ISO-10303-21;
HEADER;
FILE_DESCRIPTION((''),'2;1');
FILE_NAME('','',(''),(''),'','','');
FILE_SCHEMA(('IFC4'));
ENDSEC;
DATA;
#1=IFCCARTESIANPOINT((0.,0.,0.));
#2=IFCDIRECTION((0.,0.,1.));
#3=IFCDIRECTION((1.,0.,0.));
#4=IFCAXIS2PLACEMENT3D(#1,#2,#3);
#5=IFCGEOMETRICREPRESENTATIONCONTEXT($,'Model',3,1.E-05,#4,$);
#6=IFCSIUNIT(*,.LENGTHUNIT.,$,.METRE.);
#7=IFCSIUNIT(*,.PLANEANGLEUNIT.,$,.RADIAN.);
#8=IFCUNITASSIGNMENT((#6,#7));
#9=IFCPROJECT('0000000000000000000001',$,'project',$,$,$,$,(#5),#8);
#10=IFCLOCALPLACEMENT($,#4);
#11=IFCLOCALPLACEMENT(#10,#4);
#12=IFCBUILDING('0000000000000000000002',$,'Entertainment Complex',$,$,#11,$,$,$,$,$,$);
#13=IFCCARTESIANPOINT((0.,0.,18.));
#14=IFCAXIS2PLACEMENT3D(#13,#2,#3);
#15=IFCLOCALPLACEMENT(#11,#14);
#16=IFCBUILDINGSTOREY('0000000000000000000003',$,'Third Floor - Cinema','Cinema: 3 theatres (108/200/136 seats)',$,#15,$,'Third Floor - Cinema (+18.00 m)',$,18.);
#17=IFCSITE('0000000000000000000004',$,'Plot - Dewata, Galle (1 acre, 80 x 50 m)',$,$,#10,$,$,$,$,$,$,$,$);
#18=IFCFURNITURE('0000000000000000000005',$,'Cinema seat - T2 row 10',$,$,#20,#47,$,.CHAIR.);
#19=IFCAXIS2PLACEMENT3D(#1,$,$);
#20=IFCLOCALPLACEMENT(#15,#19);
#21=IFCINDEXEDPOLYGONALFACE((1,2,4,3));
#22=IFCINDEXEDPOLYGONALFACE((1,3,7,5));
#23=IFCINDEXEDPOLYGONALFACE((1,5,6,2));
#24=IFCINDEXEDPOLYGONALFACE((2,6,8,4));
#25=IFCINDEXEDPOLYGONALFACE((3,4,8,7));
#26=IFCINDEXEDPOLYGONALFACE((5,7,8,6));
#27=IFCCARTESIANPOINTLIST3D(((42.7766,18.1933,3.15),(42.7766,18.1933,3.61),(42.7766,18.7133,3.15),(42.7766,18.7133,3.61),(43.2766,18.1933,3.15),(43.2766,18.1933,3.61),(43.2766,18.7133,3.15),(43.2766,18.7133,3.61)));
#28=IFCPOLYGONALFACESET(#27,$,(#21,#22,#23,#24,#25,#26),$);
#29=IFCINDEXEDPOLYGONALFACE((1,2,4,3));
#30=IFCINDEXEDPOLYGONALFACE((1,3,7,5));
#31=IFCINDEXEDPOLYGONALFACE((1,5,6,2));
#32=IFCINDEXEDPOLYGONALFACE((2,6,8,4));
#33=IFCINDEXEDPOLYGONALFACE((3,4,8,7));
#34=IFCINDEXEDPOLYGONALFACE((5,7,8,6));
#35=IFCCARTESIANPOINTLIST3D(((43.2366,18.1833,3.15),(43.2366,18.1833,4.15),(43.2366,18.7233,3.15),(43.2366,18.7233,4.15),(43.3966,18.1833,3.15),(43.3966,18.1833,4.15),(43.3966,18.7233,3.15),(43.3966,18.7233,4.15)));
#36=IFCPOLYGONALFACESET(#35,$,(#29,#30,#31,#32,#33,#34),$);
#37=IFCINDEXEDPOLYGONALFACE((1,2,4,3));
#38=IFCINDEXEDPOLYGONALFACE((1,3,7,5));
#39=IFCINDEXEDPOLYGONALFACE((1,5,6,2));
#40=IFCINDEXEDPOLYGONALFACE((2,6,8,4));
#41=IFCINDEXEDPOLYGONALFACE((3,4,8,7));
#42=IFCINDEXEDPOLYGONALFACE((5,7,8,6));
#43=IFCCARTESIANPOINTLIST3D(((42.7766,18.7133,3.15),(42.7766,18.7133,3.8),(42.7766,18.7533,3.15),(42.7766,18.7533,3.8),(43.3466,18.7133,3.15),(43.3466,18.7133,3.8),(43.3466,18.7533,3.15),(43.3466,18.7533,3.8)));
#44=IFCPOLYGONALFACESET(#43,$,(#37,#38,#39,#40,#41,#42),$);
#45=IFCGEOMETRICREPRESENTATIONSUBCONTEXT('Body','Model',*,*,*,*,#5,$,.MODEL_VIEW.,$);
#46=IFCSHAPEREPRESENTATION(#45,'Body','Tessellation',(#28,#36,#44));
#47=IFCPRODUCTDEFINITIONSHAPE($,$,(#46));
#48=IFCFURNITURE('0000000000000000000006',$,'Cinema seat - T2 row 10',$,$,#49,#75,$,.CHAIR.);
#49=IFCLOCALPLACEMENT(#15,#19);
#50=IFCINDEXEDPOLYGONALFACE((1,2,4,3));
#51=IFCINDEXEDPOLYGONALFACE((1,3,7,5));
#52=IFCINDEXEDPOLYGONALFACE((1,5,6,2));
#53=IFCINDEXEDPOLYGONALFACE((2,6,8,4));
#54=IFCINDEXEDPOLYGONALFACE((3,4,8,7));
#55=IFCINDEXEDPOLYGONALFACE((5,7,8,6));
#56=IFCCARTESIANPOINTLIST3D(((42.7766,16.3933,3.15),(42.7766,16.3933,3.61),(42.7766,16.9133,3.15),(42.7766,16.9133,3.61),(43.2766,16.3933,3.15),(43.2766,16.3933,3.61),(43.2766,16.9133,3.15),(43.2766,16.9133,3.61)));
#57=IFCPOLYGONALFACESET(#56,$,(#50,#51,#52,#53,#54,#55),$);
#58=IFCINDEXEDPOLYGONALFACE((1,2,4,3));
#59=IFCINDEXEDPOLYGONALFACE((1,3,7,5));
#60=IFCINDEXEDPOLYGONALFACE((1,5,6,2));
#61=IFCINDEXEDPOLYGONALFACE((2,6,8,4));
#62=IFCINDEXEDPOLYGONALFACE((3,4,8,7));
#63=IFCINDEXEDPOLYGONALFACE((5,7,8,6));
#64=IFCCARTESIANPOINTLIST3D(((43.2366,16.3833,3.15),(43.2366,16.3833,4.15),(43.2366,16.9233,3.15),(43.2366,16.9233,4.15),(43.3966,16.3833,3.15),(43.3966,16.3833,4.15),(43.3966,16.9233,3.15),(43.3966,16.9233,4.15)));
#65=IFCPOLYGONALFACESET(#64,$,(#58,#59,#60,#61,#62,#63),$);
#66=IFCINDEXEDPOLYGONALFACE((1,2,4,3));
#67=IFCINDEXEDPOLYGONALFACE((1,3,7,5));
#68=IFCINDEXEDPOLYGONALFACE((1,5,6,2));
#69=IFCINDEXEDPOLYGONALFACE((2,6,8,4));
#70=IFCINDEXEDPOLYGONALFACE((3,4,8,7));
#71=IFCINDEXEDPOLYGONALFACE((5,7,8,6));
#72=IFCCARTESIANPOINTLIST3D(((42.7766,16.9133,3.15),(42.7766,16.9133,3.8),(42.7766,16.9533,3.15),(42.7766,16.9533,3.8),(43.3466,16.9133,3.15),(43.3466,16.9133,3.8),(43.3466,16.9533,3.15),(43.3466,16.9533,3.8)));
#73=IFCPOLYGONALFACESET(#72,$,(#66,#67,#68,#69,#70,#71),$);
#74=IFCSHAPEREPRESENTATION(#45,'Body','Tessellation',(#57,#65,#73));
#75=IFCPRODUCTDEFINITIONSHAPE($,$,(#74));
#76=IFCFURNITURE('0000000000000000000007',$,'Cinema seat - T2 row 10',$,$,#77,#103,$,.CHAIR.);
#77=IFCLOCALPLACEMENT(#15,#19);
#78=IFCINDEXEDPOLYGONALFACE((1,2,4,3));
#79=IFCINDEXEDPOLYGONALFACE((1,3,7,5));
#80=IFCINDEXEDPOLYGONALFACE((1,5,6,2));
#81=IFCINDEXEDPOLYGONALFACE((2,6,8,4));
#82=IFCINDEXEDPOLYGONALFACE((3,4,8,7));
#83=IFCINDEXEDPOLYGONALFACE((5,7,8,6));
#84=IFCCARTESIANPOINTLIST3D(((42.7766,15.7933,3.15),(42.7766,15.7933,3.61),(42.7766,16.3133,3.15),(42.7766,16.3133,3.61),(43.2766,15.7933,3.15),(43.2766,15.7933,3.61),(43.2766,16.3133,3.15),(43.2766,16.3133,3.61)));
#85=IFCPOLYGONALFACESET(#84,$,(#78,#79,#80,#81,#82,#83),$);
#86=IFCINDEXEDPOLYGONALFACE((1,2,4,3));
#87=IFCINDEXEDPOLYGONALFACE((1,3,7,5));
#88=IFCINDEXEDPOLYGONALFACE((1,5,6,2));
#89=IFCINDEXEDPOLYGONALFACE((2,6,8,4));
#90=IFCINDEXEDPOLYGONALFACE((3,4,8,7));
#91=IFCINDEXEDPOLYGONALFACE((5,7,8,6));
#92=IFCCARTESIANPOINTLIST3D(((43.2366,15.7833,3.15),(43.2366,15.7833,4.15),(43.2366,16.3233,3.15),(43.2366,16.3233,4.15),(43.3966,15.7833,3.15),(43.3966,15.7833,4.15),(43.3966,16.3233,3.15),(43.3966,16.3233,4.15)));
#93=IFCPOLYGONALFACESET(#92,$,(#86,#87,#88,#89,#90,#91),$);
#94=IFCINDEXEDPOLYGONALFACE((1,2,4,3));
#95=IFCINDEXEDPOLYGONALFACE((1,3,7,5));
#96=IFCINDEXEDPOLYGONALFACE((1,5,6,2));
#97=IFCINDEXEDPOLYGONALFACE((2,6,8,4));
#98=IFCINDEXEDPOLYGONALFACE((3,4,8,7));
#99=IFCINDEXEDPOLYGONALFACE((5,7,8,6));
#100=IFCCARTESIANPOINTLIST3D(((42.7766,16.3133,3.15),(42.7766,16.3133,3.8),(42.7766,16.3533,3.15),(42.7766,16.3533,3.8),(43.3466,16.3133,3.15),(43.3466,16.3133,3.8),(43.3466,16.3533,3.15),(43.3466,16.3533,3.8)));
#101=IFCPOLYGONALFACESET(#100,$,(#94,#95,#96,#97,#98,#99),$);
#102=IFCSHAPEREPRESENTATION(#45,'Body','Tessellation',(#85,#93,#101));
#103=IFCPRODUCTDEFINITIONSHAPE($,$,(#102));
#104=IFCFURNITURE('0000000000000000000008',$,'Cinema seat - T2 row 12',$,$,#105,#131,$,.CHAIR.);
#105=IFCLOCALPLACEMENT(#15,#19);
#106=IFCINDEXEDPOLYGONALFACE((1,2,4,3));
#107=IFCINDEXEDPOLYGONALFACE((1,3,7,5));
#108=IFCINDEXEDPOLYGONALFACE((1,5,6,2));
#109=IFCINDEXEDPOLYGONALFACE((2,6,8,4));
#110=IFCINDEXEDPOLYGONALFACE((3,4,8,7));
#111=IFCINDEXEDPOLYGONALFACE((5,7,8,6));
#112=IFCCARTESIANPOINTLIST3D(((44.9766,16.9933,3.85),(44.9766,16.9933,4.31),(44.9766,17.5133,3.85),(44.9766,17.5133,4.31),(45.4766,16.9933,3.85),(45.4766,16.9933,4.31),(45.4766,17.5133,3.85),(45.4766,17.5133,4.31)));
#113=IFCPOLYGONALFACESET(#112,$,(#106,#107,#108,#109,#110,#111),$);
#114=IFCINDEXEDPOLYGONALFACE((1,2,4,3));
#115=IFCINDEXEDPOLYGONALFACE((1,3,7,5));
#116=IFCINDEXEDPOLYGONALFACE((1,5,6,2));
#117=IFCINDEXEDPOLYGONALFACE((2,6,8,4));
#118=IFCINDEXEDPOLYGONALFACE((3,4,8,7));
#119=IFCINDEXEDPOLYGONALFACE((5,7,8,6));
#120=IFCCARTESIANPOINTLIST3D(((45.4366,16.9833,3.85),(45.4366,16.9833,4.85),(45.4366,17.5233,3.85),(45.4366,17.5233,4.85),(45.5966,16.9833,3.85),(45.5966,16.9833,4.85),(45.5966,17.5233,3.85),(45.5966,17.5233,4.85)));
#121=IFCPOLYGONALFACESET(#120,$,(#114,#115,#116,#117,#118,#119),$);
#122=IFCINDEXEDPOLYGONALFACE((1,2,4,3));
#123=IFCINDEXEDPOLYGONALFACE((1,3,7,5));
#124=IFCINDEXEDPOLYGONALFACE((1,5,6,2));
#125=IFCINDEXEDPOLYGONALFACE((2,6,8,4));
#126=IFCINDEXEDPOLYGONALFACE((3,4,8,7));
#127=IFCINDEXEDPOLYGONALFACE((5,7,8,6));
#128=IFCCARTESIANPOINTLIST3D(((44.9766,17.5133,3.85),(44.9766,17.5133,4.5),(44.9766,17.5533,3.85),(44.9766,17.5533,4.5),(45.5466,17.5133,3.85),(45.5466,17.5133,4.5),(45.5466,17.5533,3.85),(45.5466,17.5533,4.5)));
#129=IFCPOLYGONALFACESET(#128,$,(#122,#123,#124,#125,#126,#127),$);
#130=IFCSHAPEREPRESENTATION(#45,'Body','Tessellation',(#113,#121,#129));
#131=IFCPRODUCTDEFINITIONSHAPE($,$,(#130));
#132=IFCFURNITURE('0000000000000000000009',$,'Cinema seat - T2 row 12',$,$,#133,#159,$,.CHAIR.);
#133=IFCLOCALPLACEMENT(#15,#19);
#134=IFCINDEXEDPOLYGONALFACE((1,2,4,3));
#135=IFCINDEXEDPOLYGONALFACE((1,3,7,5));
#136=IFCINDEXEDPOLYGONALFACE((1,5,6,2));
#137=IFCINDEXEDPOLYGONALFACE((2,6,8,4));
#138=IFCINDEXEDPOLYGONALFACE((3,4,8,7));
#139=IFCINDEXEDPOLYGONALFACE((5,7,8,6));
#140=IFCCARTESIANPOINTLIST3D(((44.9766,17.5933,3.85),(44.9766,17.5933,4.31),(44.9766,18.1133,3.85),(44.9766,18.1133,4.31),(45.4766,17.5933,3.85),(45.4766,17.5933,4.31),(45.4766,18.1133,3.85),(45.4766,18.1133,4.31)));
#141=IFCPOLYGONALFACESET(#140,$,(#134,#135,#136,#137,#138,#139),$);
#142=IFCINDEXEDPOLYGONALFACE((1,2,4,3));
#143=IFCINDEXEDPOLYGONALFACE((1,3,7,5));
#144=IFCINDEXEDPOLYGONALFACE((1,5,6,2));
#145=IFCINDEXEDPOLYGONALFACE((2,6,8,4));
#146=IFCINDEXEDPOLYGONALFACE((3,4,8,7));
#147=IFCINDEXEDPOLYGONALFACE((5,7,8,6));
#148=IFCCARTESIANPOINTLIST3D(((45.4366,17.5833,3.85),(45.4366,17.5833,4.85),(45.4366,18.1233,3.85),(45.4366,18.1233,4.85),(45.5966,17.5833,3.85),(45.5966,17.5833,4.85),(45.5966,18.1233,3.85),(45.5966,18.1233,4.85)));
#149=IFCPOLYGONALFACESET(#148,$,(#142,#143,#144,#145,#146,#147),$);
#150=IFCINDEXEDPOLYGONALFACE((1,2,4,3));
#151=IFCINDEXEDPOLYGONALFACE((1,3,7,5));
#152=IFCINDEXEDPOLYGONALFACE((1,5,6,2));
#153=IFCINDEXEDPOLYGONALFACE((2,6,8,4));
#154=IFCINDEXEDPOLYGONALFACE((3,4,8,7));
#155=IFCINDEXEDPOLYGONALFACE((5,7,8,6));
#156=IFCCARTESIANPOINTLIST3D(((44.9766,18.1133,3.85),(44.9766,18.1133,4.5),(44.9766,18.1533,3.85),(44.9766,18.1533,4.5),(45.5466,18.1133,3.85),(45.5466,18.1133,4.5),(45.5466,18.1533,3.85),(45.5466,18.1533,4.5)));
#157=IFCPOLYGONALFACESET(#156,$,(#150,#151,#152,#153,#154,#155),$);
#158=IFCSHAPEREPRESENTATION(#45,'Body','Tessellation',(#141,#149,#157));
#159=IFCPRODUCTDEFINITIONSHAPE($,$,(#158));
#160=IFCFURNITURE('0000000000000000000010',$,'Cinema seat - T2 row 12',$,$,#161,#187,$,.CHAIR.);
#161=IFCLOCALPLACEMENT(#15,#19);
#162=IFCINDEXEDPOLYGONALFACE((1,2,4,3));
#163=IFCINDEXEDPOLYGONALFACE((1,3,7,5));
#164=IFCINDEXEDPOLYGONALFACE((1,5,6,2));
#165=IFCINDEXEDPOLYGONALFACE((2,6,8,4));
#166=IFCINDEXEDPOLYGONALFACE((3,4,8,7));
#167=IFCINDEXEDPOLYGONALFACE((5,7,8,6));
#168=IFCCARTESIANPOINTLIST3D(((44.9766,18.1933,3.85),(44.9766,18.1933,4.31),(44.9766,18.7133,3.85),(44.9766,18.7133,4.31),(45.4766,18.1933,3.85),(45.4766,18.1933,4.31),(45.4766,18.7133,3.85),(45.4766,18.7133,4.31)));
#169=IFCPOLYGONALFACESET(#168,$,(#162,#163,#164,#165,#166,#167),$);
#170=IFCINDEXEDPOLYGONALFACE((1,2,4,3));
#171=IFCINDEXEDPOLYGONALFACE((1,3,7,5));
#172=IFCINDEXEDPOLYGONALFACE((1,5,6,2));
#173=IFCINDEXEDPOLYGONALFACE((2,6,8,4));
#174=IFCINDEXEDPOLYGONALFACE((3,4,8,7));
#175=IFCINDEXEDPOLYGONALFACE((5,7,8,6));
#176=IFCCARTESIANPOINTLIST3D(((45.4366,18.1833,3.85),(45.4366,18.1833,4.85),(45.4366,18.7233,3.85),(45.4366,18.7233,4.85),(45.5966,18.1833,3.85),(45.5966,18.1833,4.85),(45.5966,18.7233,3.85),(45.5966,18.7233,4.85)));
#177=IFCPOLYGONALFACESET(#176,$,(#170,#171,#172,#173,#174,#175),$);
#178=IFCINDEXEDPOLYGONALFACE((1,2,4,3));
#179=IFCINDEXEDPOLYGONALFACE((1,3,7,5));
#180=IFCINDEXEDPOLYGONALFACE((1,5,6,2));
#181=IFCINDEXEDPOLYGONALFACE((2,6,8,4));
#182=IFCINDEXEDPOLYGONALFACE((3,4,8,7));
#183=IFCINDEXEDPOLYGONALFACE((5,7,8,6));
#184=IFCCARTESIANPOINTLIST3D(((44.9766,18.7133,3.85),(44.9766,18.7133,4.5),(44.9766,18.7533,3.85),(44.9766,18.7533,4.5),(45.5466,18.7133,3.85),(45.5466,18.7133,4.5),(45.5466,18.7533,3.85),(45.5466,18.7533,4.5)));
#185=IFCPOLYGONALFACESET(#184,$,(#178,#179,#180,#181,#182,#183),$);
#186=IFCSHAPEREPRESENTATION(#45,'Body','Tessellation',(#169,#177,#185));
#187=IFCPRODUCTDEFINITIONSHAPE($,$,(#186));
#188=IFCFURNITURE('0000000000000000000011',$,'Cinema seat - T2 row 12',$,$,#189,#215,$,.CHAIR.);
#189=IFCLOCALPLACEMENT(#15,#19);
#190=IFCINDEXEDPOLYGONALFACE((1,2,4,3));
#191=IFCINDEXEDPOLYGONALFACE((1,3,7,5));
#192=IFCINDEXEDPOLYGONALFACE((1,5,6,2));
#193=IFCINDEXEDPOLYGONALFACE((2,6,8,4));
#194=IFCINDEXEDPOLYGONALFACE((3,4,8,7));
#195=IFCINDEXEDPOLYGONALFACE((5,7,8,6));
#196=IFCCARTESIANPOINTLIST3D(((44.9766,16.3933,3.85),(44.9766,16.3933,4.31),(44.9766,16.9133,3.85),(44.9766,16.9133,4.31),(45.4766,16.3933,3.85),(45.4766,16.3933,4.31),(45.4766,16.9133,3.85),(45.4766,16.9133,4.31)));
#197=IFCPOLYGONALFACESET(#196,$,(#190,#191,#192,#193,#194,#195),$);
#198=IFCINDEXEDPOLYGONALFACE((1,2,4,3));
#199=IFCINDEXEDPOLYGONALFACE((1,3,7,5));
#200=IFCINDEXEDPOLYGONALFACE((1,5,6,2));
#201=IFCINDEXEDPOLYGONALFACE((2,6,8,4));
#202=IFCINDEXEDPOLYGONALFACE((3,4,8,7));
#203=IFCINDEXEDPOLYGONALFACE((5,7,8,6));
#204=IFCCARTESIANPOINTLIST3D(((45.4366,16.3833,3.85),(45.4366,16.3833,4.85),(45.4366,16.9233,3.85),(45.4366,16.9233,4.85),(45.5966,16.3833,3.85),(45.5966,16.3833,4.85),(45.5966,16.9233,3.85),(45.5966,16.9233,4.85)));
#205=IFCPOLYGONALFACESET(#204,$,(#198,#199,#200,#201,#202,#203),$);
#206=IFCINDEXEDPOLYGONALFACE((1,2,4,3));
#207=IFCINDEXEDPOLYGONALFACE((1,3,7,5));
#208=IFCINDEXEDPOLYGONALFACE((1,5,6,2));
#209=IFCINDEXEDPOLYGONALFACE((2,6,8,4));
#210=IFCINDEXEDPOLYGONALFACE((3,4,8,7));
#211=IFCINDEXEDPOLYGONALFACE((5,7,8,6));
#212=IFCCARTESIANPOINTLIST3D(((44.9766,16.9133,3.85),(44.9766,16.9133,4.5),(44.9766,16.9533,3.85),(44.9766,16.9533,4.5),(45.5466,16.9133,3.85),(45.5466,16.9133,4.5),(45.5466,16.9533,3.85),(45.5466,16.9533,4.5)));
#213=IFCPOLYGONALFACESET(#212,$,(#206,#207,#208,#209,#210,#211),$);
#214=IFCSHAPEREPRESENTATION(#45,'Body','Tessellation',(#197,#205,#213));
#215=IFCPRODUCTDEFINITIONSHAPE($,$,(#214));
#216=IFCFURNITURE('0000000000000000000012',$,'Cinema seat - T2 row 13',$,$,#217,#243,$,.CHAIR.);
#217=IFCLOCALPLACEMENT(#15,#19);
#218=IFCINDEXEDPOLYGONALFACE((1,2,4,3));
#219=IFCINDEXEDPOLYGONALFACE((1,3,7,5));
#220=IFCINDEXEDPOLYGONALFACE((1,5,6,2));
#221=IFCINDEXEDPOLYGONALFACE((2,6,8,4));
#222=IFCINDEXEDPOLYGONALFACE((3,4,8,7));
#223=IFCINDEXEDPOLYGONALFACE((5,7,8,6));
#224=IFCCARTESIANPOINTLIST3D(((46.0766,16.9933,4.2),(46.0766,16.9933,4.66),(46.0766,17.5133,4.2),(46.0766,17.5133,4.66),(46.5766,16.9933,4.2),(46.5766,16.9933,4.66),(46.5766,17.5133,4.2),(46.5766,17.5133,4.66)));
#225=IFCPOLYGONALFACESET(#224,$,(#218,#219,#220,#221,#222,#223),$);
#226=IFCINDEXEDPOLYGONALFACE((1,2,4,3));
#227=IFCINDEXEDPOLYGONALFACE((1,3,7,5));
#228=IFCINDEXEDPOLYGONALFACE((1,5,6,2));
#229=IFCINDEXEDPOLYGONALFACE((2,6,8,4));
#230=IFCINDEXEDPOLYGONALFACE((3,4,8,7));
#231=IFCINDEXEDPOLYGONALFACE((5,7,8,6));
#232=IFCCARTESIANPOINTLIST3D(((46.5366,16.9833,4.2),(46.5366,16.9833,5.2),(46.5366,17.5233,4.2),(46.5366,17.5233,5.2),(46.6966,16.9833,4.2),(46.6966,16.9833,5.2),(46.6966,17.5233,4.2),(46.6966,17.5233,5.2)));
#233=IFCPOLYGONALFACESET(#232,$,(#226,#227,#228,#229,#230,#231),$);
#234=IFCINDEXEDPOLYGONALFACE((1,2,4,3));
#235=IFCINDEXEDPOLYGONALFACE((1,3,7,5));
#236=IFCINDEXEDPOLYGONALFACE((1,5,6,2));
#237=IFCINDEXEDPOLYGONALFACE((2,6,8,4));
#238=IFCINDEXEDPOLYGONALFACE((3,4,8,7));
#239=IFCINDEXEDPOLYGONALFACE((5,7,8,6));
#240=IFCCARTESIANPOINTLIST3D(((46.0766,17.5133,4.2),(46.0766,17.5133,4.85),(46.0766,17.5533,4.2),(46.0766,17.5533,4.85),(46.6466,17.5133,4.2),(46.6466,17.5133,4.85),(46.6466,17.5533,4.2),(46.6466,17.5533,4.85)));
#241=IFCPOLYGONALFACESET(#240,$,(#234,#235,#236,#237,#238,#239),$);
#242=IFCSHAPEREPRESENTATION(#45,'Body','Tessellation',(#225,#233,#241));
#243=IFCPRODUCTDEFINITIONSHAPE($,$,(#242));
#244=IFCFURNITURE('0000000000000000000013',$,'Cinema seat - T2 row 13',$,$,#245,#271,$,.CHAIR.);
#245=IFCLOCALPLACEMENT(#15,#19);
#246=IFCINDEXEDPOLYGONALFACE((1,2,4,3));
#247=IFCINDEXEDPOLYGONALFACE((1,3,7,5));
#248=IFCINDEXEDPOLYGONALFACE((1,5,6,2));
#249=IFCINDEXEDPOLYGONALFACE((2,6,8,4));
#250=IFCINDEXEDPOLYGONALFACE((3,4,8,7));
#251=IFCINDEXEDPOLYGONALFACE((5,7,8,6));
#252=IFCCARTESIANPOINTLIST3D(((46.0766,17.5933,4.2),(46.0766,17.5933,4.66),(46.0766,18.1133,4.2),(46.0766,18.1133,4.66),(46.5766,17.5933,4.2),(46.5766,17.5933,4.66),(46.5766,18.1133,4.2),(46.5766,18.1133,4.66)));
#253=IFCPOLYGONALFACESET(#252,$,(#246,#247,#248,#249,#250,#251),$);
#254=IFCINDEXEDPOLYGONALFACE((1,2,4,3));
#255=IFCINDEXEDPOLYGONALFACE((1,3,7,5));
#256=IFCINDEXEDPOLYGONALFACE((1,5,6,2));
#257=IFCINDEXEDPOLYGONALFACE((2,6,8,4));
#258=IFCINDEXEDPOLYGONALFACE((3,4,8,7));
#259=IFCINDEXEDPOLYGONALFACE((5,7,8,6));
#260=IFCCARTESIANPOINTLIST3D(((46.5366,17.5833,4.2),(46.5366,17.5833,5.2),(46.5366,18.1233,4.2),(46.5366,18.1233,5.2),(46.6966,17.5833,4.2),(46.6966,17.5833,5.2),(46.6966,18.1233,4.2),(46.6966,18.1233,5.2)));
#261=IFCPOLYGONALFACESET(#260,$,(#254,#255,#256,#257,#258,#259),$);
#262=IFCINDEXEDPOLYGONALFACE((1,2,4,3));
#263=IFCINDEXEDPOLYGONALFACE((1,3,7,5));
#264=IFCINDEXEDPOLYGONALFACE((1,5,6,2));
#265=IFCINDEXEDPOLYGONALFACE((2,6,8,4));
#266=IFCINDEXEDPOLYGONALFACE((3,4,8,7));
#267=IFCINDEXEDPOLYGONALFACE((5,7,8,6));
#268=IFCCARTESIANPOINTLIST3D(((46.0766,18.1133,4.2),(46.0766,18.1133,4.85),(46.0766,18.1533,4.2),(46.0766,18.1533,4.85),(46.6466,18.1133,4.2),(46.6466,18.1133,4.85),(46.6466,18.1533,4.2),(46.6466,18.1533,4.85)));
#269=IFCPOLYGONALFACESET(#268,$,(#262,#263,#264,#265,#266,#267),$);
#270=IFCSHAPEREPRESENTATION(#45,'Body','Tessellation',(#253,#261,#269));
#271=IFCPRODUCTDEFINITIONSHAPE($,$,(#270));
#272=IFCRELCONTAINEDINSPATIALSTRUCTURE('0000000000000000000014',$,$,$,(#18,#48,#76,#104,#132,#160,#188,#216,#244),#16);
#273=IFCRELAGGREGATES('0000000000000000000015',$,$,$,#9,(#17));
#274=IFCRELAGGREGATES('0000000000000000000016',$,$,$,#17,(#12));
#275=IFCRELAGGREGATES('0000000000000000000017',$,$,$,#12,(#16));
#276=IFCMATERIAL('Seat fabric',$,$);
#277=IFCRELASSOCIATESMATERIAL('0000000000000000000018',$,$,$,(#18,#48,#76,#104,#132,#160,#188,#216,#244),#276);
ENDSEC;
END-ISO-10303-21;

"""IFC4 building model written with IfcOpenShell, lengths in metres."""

from ifc_helpers import new_model, si_unit, frame, origin_with_axes, place, context, subcontext, project, spatial, polyline, outline, extrude, material, element, save


model = new_model("IFC4")

# Units and contexts
model_context = context("Model", 3, precision=1e-05, world=origin_with_axes())
body_context = subcontext(model_context, "Body", "Model", "MODEL_VIEW")
ifc_project = project(units=[si_unit("LENGTHUNIT", "METRE"), si_unit("PLANEANGLEUNIT", "RADIAN")], contexts=[model_context])

# Site, building, storey
site_placement = place(None, origin_with_axes())
site = spatial("IfcSite", under=ifc_project, at=site_placement, Name="Plot - Dewata, Galle (1 acre, 80 x 50 m)")
building_placement = place(site_placement, origin_with_axes())
building = spatial("IfcBuilding", under=site, at=building_placement, Name="Entertainment Complex")
storey_placement = place(building_placement, frame((0.0, 0.0, 18.0), z_axis=(0.0, 0.0, 1.0), x_axis=(1.0, 0.0, 0.0)))
storey = spatial("IfcBuildingStorey", under=building, at=storey_placement, Name="Third Floor - Cinema", Description="Cinema: 3 theatres (108/200/136 seats)", LongName="Third Floor - Cinema (+18.00 m)", Elevation=18.0)

# Furniture
ifc_material_1 = material(Name="Seat fabric")
for number, where, z_axis, x_axis, name in (
    (1, (43.3966, 18.4533, 3.15), (0.0, 0.0, 1.0), (1.0, 0.0, 0.0), "Cinema seat - T2 row 10"),
    (2, (43.3966, 16.6533, 3.15), (0.0, 0.0, 1.0), (1.0, 0.0, 0.0), "Cinema seat - T2 row 10"),
    (3, (43.3966, 16.0533, 3.15), (0.0, 0.0, 1.0), (1.0, 0.0, 0.0), "Cinema seat - T2 row 10"),
    (4, (45.5966, 17.2533, 3.85), (0.0, 0.0, 1.0), (1.0, 0.0, 0.0), "Cinema seat - T2 row 12"),
    (5, (45.5966, 17.8533, 3.85), (0.0, 0.0, 1.0), (1.0, 0.0, 0.0), "Cinema seat - T2 row 12"),
    (6, (45.5966, 18.4533, 3.85), (0.0, 0.0, 1.0), (1.0, 0.0, 0.0), "Cinema seat - T2 row 12"),
    (7, (45.5966, 16.6533, 3.85), (0.0, 0.0, 1.0), (1.0, 0.0, 0.0), "Cinema seat - T2 row 12"),
    (8, (46.6966, 17.2533, 4.2), (0.0, 0.0, 1.0), (1.0, 0.0, 0.0), "Cinema seat - T2 row 13"),
    (9, (46.6966, 17.8533, 4.2), (0.0, 0.0, 1.0), (1.0, 0.0, 0.0), "Cinema seat - T2 row 13"),
):
    element("IfcFurniture", number, at=place(storey_placement, frame(where, z_axis=z_axis, x_axis=x_axis)), inside=storey, material=ifc_material_1, Name=name, PredefinedType="CHAIR", context=body_context, shape_type="SweptSolid", body=[
        extrude(outline(polyline([(-0.62, -0.26), (-0.12, -0.26), (-0.12, 0.26), (-0.62, 0.26), (-0.62, -0.26)])), origin_with_axes(), (0.0, 0.0, 1.0), 0.46),
        extrude(outline(polyline([(-0.16, -0.27), (0.0, -0.27), (0.0, 0.27), (-0.16, 0.27), (-0.16, -0.27)])), origin_with_axes(), (0.0, 0.0, 1.0), 1.0),
        extrude(outline(polyline([(-0.62, 0.26), (-0.05, 0.26), (-0.05, 0.3), (-0.62, 0.3), (-0.62, 0.26)])), origin_with_axes(), (0.0, 0.0, 1.0), 0.65),
    ])

save(model, "model.ifc")
